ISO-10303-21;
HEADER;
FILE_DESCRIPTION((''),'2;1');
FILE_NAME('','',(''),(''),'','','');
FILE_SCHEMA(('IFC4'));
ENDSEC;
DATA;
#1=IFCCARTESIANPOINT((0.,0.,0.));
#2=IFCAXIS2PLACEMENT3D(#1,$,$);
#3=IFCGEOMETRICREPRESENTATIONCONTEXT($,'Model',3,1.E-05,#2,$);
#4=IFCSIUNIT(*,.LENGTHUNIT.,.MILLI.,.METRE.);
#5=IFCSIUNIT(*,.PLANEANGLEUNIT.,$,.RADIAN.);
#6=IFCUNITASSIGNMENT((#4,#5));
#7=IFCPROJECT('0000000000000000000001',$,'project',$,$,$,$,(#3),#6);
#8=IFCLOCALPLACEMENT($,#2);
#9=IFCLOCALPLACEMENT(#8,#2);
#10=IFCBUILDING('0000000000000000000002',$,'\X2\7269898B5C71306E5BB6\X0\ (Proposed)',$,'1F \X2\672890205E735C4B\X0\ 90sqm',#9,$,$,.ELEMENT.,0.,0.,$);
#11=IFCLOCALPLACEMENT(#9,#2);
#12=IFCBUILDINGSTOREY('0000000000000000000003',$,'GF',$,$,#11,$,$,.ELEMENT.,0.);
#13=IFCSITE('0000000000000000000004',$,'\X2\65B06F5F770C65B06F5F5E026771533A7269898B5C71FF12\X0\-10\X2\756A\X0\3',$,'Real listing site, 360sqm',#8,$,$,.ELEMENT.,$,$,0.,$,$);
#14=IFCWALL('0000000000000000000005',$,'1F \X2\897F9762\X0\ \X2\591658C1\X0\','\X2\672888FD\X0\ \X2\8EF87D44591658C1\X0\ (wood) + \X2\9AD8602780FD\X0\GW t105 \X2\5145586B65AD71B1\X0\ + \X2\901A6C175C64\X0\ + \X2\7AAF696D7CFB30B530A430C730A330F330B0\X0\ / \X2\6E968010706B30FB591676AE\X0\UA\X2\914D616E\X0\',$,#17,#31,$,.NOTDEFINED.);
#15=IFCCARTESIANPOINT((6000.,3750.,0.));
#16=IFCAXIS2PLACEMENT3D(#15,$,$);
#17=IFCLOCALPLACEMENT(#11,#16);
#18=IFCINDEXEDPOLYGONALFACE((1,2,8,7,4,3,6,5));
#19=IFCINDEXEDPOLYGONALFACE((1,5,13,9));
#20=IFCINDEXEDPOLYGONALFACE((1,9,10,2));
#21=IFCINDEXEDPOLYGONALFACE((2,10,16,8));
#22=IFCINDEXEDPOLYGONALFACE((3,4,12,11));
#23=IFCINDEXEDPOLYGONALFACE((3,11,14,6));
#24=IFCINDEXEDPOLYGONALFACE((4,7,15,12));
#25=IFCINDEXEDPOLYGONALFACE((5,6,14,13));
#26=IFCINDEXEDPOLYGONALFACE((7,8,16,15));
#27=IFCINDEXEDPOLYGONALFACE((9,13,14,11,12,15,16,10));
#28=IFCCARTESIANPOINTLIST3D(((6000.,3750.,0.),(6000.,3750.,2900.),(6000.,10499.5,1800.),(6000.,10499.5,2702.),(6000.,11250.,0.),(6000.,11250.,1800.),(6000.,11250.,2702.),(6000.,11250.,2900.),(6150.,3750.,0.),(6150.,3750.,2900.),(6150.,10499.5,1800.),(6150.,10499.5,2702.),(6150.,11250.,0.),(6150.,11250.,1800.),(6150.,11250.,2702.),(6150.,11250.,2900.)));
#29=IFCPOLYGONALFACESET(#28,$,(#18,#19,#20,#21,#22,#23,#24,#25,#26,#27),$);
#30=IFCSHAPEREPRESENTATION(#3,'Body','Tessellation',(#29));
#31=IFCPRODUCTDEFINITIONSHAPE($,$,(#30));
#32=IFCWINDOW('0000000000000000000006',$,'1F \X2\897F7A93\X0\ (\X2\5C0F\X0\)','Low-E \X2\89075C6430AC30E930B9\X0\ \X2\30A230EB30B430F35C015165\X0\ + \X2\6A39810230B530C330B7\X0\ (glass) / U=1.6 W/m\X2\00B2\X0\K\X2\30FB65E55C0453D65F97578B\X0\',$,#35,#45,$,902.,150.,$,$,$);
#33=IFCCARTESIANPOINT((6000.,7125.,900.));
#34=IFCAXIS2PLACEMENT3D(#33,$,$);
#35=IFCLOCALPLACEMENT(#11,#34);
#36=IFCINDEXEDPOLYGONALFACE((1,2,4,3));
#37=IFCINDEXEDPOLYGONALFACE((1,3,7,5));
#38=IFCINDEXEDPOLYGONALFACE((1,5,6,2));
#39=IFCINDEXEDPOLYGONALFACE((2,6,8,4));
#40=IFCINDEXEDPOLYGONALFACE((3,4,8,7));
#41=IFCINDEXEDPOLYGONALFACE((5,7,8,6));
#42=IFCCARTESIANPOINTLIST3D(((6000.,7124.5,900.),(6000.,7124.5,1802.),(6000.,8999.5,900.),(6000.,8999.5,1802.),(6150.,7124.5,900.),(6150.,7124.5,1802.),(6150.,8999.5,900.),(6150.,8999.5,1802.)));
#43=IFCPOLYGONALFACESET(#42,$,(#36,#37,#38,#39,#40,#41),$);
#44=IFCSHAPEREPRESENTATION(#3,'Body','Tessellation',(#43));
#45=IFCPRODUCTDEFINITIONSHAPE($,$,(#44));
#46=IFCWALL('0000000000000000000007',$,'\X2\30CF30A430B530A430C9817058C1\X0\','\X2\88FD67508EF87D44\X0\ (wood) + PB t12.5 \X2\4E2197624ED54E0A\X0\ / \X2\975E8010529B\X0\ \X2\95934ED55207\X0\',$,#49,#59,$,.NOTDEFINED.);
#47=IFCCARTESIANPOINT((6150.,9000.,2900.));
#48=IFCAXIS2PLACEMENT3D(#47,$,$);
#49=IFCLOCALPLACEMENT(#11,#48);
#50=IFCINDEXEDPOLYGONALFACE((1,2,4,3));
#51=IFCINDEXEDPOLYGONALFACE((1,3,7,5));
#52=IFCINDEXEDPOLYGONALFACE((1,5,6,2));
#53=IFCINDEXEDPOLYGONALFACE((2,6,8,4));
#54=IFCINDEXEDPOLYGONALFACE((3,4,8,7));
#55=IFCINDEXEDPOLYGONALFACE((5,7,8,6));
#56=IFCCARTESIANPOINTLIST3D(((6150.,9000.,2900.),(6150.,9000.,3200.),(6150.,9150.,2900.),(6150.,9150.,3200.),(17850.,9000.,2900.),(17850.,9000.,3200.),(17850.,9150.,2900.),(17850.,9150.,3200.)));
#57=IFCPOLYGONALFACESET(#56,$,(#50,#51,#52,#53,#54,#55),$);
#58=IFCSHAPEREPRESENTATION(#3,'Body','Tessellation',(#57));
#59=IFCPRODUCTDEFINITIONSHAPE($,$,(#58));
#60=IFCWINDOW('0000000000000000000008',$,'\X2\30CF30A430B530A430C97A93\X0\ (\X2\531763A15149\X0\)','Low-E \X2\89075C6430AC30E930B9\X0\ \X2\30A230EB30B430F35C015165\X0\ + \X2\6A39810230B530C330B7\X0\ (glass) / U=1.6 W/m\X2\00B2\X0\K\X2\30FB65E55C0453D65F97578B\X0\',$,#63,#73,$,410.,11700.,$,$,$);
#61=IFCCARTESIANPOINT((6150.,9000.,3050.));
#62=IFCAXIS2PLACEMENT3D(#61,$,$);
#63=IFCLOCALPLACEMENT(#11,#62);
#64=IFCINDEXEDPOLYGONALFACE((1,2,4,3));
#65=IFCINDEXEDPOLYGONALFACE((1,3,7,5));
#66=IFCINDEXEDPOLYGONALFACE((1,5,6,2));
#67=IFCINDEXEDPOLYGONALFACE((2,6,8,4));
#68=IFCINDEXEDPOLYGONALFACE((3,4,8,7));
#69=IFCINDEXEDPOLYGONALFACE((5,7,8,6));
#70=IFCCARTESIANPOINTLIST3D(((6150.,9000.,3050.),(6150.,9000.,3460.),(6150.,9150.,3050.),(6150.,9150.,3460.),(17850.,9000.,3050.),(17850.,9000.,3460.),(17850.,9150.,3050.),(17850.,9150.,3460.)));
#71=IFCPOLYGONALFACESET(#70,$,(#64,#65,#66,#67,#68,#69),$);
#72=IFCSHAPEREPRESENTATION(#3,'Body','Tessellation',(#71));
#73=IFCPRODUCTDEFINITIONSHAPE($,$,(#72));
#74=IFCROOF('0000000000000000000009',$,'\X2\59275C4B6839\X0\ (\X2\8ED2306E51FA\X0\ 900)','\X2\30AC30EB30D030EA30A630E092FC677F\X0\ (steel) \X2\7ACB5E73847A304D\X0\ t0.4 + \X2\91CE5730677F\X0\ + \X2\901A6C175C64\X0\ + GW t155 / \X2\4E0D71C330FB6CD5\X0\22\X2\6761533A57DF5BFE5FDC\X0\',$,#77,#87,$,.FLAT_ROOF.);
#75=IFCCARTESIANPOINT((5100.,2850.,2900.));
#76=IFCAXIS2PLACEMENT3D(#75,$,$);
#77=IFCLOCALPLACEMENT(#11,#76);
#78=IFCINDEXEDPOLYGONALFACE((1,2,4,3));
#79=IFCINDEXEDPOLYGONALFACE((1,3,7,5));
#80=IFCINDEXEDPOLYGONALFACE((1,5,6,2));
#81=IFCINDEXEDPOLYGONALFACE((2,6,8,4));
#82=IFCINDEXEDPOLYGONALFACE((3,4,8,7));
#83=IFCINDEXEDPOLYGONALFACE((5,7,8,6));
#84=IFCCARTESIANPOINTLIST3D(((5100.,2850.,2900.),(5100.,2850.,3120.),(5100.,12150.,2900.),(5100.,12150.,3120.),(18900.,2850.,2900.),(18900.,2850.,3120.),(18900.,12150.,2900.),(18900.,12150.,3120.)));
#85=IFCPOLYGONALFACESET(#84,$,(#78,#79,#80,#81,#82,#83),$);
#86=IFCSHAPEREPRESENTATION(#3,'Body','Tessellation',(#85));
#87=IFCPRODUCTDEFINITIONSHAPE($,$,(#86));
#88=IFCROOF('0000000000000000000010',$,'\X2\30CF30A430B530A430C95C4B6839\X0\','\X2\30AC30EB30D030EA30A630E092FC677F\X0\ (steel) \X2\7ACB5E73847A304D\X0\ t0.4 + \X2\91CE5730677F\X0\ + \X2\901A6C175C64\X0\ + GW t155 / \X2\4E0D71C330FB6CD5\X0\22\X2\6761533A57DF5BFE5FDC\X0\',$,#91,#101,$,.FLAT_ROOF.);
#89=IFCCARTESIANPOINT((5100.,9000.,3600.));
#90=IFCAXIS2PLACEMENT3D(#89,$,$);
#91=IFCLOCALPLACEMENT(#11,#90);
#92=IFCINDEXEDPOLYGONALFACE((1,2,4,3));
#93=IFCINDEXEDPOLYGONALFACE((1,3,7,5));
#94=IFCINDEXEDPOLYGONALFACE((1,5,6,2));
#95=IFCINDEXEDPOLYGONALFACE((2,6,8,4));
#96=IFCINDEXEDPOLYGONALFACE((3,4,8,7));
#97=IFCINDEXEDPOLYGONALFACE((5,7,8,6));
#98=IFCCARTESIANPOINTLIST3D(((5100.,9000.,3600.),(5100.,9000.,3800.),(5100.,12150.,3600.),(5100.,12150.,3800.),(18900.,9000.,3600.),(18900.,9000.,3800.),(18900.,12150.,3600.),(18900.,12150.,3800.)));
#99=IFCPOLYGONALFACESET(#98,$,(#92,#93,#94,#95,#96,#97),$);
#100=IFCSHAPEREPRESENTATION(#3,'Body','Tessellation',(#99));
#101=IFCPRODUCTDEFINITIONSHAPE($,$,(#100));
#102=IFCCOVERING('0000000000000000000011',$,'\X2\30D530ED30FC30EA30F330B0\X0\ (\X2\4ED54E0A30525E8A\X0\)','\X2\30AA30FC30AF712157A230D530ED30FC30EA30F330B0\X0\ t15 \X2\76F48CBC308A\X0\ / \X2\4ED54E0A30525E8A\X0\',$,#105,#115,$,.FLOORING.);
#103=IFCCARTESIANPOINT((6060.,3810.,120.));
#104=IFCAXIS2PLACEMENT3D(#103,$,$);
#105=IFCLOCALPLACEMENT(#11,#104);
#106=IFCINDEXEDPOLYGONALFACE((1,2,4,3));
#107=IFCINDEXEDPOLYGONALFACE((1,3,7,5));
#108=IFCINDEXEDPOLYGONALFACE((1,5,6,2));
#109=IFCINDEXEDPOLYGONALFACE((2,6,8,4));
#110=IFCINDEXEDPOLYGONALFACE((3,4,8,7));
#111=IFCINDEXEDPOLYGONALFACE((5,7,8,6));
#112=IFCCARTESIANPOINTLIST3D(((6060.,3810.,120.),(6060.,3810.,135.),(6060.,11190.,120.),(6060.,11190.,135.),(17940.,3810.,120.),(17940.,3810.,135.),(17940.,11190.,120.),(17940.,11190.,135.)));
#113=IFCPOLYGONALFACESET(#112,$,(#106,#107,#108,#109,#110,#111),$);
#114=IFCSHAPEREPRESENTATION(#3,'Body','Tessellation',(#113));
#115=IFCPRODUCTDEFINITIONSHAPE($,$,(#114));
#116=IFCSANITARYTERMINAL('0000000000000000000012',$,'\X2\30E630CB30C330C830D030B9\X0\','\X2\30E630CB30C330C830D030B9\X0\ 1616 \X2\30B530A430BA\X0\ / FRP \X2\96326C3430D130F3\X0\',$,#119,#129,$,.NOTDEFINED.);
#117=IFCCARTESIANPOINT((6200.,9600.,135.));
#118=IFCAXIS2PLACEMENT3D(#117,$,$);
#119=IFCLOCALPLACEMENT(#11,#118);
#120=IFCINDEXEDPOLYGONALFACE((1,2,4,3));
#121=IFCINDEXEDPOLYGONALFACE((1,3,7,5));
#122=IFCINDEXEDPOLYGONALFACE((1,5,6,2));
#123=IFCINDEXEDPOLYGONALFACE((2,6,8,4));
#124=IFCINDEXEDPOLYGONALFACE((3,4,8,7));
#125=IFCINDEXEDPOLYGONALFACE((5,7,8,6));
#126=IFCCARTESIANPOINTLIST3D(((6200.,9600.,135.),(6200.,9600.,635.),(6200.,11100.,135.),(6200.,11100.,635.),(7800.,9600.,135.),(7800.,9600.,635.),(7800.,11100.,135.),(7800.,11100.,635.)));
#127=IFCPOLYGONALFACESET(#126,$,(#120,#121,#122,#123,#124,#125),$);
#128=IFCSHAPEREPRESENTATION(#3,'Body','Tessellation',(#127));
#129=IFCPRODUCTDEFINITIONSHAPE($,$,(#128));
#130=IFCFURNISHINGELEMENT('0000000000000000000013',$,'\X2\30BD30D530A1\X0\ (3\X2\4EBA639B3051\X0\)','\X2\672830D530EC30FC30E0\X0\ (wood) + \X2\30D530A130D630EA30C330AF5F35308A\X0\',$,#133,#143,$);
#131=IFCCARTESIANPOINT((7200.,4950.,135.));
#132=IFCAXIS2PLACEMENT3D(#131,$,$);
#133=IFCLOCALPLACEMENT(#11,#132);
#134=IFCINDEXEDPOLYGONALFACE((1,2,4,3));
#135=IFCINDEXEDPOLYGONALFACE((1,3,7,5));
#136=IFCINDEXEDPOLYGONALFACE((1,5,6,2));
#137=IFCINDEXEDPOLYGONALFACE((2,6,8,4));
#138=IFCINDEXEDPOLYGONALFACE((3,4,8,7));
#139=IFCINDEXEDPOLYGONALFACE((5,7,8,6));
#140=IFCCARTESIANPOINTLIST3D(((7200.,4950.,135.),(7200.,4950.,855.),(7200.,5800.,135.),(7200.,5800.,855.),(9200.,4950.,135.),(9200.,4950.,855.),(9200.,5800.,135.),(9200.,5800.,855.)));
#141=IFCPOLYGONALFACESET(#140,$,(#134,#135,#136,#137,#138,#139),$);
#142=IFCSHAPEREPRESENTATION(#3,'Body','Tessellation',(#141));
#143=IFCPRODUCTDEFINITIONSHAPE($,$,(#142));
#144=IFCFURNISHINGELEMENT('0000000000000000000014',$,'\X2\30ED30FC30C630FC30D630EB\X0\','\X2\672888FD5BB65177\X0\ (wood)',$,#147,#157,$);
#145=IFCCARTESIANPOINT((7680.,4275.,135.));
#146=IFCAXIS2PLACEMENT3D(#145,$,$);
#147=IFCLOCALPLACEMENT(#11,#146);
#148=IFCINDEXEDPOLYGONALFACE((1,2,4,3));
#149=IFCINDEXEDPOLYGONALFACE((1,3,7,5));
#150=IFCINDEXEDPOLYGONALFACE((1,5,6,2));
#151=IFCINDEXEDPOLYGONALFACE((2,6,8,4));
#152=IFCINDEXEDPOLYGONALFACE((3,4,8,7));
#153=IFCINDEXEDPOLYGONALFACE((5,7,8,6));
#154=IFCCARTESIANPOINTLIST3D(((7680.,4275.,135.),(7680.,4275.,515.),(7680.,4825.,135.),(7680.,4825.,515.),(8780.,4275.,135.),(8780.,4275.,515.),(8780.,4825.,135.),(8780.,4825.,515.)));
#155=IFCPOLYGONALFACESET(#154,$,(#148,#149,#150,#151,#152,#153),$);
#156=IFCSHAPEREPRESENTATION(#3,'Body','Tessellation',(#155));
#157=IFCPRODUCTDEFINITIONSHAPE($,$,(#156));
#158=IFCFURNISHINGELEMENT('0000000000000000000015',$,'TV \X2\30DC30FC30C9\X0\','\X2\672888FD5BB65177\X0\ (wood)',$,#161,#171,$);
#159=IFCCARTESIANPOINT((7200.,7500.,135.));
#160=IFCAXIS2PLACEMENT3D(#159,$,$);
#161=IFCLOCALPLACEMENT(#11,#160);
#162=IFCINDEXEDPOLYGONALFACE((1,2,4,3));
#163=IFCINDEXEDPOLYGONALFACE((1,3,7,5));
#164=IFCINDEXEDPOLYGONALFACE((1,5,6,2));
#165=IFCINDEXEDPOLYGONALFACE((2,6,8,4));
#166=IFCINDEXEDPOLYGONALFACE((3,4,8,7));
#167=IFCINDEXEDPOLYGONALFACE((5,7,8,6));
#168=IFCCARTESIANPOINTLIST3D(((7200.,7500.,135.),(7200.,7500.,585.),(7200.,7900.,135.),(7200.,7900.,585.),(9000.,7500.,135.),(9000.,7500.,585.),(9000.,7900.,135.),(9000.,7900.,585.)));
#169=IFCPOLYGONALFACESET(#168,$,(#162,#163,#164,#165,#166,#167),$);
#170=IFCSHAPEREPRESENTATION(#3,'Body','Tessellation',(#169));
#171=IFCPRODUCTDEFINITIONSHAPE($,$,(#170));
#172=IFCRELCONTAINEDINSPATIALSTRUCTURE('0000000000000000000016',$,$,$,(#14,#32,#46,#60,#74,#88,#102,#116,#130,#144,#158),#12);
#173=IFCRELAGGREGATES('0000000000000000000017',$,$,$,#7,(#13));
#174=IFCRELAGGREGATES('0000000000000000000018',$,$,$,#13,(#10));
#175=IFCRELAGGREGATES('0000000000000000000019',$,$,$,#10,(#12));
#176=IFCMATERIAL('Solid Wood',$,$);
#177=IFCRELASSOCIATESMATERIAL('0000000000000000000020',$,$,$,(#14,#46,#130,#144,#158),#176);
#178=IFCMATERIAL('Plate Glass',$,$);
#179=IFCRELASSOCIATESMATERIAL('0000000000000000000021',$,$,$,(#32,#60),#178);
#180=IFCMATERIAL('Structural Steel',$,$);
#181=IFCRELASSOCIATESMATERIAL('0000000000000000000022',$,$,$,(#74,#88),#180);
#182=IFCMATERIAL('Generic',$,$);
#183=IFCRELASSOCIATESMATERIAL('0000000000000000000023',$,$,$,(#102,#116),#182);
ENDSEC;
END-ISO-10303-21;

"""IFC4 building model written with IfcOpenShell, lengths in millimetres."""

from ifc_helpers import new_model, si_unit, frame, frame_2d, origin, place, context, project, spatial, rectangle, extrude, material, element, fill, save


model = new_model("IFC4")

# Units and contexts
model_context = context("Model", 3, precision=1e-05, world=origin())
ifc_project = project(units=[si_unit("LENGTHUNIT", "METRE", prefix="MILLI"), si_unit("PLANEANGLEUNIT", "RADIAN")], contexts=[model_context])

# Site, building, storey
site_placement = place(None, origin())
site = spatial("IfcSite", under=ifc_project, at=site_placement, Name="新潟県新潟市東区物見山２-10番3", ObjectType="Real listing site, 360sqm", CompositionType="ELEMENT", RefElevation=0.0)
building_placement = place(site_placement, origin())
building = spatial("IfcBuilding", under=site, at=building_placement, Name="物見山の家 (Proposed)", ObjectType="1F 木造平屋 90sqm", CompositionType="ELEMENT", ElevationOfRefHeight=0.0, ElevationOfTerrain=0.0)
storey_placement = place(building_placement, origin())
storey = spatial("IfcBuildingStorey", under=building, at=storey_placement, Name="GF", CompositionType="ELEMENT", Elevation=0.0)

# Shared definitions
ifc_material_1 = material(Name="Solid Wood")

# Shared definitions
ifc_material_2 = material(Name="Plate Glass")

# Wall, opening, window
wall_1_placement = place(storey_placement, frame((6000.0, 3750.0, 0.0)))
wall_1 = element("IfcWall", 1, at=wall_1_placement, inside=storey, material=ifc_material_1, Name="1F 西面 外壁", Description="木製 軸組外壁 (wood) + 高性能GW t105 充填断熱 + 通気層 + 窯業系サイディング / 準耐火・外皮UA配慮", PredefinedType="NOTDEFINED", context=model_context, shape_type="SweptSolid", body=[
    extrude(rectangle(XDim=150.0, YDim=7500.0, at=frame_2d((75.0, 3750.0))), frame((6000.0, 3750.0, 0.0)), (0.0, 0.0, 1.0), 2900.0),
])
opening_1_placement = place(storey_placement, frame((6000.0, 7125.0, 900.0)))
opening_1 = element("IfcOpeningElement", 2, at=opening_1_placement, cuts=wall_1, PredefinedType="NOTDEFINED", context=model_context, shape_type="SweptSolid", body=[
    extrude(rectangle(XDim=150.0, YDim=1875.0, at=frame_2d((75.0, 937.0))), frame((6000.0, 7125.0, 900.0)), (0.0, 0.0, 1.0), 902.0),
])
window_1_placement = place(storey_placement, frame((6000.0, 7125.0, 900.0)))
window_1 = element("IfcWindow", 3, at=window_1_placement, inside=storey, material=ifc_material_2, Name="1F 西窓 (小)", Description="Low-E 複層ガラス アルゴン封入 + 樹脂サッシ (glass) / U=1.6 W/m²K・日射取得型", OverallHeight=902.0, OverallWidth=150.0, context=model_context, shape_type="SweptSolid", body=[
    extrude(rectangle(XDim=150.0, YDim=1875.0, at=frame_2d((75.0, 937.0))), frame((6000.0, 7125.0, 900.0)), (0.0, 0.0, 1.0), 902.0),
])
fill(opening_1, window_1)

# Wall, opening, window
wall_2_placement = place(storey_placement, frame((6150.0, 9000.0, 2900.0)))
wall_2 = element("IfcWall", 4, at=wall_2_placement, inside=storey, material=ifc_material_1, Name="ハイサイド腰壁", Description="製材軸組 (wood) + PB t12.5 両面仕上 / 非耐力 間仕切", PredefinedType="NOTDEFINED", context=model_context, shape_type="SweptSolid", body=[
    extrude(rectangle(XDim=11700.0, YDim=150.0, at=frame_2d((5850.0, 75.0))), frame((6150.0, 9000.0, 2900.0)), (0.0, 0.0, 1.0), 700.0),
])
opening_2_placement = place(storey_placement, frame((6150.0, 9000.0, 3050.0)))
opening_2 = element("IfcOpeningElement", 5, at=opening_2_placement, cuts=wall_2, PredefinedType="NOTDEFINED", context=model_context, shape_type="SweptSolid", body=[
    extrude(rectangle(XDim=11700.0, YDim=150.0, at=frame_2d((5850.0, 75.0))), frame((6150.0, 9000.0, 3050.0)), (0.0, 0.0, 1.0), 410.0),
])
window_2_placement = place(storey_placement, frame((6150.0, 9000.0, 3050.0)))
window_2 = element("IfcWindow", 6, at=window_2_placement, inside=storey, material=ifc_material_2, Name="ハイサイド窓 (北採光)", Description="Low-E 複層ガラス アルゴン封入 + 樹脂サッシ (glass) / U=1.6 W/m²K・日射取得型", OverallHeight=410.0, OverallWidth=11700.0, context=model_context, shape_type="SweptSolid", body=[
    extrude(rectangle(XDim=11700.0, YDim=150.0, at=frame_2d((5850.0, 75.0))), frame((6150.0, 9000.0, 3050.0)), (0.0, 0.0, 1.0), 410.0),
])
fill(opening_2, window_2)

# Roofs
ifc_material_3 = material(Name="Structural Steel")
roof_1_placement = place(storey_placement, frame((5100.0, 2850.0, 2900.0)))
element("IfcRoof", 7, at=roof_1_placement, inside=storey, material=ifc_material_3, Name="大屋根 (軒の出 900)", Description="ガルバリウム鋼板 (steel) 立平葺き t0.4 + 野地板 + 通気層 + GW t155 / 不燃・法22条区域対応", PredefinedType="FLAT_ROOF", context=model_context, shape_type="SweptSolid", body=[
    extrude(rectangle(XDim=13800.0, YDim=9300.0, at=frame_2d((6900.0, 4650.0))), frame((5100.0, 2850.0, 2900.0)), (0.0, 0.0, 1.0), 220.0),
])
roof_2_placement = place(storey_placement, frame((5100.0, 9000.0, 3600.0)))
element("IfcRoof", 8, at=roof_2_placement, inside=storey, material=ifc_material_3, Name="ハイサイド屋根", Description="ガルバリウム鋼板 (steel) 立平葺き t0.4 + 野地板 + 通気層 + GW t155 / 不燃・法22条区域対応", PredefinedType="FLAT_ROOF", context=model_context, shape_type="SweptSolid", body=[
    extrude(rectangle(XDim=13800.0, YDim=3150.0, at=frame_2d((6900.0, 1575.0))), frame((5100.0, 9000.0, 3600.0)), (0.0, 0.0, 1.0), 200.0),
])

# Covering
ifc_material_4 = material(Name="Generic")
covering_placement = place(storey_placement, frame((6060.0, 3810.0, 120.0)))
element("IfcCovering", 9, at=covering_placement, inside=storey, material=ifc_material_4, Name="フローリング (仕上げ床)", Description="オーク無垢フローリング t15 直貼り / 仕上げ床", PredefinedType="FLOORING", context=model_context, shape_type="SweptSolid", body=[
    extrude(rectangle(XDim=11880.0, YDim=7380.0, at=frame_2d((5940.0, 3690.0))), frame((6060.0, 3810.0, 120.0)), (0.0, 0.0, 1.0), 15.0),
])

# Sanitary terminal
sanitary_terminal_placement = place(storey_placement, frame((6200.0, 9600.0, 135.0)))
element("IfcSanitaryTerminal", 10, at=sanitary_terminal_placement, inside=storey, material=ifc_material_4, Name="ユニットバス", Description="ユニットバス 1616 サイズ / FRP 防水パン", PredefinedType="NOTDEFINED", context=model_context, shape_type="SweptSolid", body=[
    extrude(rectangle(XDim=1600.0, YDim=1500.0, at=frame_2d((800.0, 750.0))), frame((6200.0, 9600.0, 135.0)), (0.0, 0.0, 1.0), 500.0),
])

# Furnishing elements
furnishing_1_placement = place(storey_placement, frame((7200.0, 4950.0, 135.0)))
element("IfcFurnishingElement", 11, at=furnishing_1_placement, inside=storey, material=ifc_material_1, Name="ソファ (3人掛け)", Description="木フレーム (wood) + ファブリック張り", context=model_context, shape_type="SweptSolid", body=[
    extrude(rectangle(XDim=2000.0, YDim=850.0, at=frame_2d((1000.0, 425.0))), frame((7200.0, 4950.0, 135.0)), (0.0, 0.0, 1.0), 720.0),
])
furnishing_2_placement = place(storey_placement, frame((7680.0, 4275.0, 135.0)))
element("IfcFurnishingElement", 12, at=furnishing_2_placement, inside=storey, material=ifc_material_1, Name="ローテーブル", Description="木製家具 (wood)", context=model_context, shape_type="SweptSolid", body=[
    extrude(rectangle(XDim=1100.0, YDim=550.0, at=frame_2d((550.0, 275.0))), frame((7680.0, 4275.0, 135.0)), (0.0, 0.0, 1.0), 380.0),
])
furnishing_3_placement = place(storey_placement, frame((7200.0, 7500.0, 135.0)))
element("IfcFurnishingElement", 13, at=furnishing_3_placement, inside=storey, material=ifc_material_1, Name="TV ボード", Description="木製家具 (wood)", context=model_context, shape_type="SweptSolid", body=[
    extrude(rectangle(XDim=1800.0, YDim=400.0, at=frame_2d((900.0, 200.0))), frame((7200.0, 7500.0, 135.0)), (0.0, 0.0, 1.0), 450.0),
])

save(model, "model.ifc")
